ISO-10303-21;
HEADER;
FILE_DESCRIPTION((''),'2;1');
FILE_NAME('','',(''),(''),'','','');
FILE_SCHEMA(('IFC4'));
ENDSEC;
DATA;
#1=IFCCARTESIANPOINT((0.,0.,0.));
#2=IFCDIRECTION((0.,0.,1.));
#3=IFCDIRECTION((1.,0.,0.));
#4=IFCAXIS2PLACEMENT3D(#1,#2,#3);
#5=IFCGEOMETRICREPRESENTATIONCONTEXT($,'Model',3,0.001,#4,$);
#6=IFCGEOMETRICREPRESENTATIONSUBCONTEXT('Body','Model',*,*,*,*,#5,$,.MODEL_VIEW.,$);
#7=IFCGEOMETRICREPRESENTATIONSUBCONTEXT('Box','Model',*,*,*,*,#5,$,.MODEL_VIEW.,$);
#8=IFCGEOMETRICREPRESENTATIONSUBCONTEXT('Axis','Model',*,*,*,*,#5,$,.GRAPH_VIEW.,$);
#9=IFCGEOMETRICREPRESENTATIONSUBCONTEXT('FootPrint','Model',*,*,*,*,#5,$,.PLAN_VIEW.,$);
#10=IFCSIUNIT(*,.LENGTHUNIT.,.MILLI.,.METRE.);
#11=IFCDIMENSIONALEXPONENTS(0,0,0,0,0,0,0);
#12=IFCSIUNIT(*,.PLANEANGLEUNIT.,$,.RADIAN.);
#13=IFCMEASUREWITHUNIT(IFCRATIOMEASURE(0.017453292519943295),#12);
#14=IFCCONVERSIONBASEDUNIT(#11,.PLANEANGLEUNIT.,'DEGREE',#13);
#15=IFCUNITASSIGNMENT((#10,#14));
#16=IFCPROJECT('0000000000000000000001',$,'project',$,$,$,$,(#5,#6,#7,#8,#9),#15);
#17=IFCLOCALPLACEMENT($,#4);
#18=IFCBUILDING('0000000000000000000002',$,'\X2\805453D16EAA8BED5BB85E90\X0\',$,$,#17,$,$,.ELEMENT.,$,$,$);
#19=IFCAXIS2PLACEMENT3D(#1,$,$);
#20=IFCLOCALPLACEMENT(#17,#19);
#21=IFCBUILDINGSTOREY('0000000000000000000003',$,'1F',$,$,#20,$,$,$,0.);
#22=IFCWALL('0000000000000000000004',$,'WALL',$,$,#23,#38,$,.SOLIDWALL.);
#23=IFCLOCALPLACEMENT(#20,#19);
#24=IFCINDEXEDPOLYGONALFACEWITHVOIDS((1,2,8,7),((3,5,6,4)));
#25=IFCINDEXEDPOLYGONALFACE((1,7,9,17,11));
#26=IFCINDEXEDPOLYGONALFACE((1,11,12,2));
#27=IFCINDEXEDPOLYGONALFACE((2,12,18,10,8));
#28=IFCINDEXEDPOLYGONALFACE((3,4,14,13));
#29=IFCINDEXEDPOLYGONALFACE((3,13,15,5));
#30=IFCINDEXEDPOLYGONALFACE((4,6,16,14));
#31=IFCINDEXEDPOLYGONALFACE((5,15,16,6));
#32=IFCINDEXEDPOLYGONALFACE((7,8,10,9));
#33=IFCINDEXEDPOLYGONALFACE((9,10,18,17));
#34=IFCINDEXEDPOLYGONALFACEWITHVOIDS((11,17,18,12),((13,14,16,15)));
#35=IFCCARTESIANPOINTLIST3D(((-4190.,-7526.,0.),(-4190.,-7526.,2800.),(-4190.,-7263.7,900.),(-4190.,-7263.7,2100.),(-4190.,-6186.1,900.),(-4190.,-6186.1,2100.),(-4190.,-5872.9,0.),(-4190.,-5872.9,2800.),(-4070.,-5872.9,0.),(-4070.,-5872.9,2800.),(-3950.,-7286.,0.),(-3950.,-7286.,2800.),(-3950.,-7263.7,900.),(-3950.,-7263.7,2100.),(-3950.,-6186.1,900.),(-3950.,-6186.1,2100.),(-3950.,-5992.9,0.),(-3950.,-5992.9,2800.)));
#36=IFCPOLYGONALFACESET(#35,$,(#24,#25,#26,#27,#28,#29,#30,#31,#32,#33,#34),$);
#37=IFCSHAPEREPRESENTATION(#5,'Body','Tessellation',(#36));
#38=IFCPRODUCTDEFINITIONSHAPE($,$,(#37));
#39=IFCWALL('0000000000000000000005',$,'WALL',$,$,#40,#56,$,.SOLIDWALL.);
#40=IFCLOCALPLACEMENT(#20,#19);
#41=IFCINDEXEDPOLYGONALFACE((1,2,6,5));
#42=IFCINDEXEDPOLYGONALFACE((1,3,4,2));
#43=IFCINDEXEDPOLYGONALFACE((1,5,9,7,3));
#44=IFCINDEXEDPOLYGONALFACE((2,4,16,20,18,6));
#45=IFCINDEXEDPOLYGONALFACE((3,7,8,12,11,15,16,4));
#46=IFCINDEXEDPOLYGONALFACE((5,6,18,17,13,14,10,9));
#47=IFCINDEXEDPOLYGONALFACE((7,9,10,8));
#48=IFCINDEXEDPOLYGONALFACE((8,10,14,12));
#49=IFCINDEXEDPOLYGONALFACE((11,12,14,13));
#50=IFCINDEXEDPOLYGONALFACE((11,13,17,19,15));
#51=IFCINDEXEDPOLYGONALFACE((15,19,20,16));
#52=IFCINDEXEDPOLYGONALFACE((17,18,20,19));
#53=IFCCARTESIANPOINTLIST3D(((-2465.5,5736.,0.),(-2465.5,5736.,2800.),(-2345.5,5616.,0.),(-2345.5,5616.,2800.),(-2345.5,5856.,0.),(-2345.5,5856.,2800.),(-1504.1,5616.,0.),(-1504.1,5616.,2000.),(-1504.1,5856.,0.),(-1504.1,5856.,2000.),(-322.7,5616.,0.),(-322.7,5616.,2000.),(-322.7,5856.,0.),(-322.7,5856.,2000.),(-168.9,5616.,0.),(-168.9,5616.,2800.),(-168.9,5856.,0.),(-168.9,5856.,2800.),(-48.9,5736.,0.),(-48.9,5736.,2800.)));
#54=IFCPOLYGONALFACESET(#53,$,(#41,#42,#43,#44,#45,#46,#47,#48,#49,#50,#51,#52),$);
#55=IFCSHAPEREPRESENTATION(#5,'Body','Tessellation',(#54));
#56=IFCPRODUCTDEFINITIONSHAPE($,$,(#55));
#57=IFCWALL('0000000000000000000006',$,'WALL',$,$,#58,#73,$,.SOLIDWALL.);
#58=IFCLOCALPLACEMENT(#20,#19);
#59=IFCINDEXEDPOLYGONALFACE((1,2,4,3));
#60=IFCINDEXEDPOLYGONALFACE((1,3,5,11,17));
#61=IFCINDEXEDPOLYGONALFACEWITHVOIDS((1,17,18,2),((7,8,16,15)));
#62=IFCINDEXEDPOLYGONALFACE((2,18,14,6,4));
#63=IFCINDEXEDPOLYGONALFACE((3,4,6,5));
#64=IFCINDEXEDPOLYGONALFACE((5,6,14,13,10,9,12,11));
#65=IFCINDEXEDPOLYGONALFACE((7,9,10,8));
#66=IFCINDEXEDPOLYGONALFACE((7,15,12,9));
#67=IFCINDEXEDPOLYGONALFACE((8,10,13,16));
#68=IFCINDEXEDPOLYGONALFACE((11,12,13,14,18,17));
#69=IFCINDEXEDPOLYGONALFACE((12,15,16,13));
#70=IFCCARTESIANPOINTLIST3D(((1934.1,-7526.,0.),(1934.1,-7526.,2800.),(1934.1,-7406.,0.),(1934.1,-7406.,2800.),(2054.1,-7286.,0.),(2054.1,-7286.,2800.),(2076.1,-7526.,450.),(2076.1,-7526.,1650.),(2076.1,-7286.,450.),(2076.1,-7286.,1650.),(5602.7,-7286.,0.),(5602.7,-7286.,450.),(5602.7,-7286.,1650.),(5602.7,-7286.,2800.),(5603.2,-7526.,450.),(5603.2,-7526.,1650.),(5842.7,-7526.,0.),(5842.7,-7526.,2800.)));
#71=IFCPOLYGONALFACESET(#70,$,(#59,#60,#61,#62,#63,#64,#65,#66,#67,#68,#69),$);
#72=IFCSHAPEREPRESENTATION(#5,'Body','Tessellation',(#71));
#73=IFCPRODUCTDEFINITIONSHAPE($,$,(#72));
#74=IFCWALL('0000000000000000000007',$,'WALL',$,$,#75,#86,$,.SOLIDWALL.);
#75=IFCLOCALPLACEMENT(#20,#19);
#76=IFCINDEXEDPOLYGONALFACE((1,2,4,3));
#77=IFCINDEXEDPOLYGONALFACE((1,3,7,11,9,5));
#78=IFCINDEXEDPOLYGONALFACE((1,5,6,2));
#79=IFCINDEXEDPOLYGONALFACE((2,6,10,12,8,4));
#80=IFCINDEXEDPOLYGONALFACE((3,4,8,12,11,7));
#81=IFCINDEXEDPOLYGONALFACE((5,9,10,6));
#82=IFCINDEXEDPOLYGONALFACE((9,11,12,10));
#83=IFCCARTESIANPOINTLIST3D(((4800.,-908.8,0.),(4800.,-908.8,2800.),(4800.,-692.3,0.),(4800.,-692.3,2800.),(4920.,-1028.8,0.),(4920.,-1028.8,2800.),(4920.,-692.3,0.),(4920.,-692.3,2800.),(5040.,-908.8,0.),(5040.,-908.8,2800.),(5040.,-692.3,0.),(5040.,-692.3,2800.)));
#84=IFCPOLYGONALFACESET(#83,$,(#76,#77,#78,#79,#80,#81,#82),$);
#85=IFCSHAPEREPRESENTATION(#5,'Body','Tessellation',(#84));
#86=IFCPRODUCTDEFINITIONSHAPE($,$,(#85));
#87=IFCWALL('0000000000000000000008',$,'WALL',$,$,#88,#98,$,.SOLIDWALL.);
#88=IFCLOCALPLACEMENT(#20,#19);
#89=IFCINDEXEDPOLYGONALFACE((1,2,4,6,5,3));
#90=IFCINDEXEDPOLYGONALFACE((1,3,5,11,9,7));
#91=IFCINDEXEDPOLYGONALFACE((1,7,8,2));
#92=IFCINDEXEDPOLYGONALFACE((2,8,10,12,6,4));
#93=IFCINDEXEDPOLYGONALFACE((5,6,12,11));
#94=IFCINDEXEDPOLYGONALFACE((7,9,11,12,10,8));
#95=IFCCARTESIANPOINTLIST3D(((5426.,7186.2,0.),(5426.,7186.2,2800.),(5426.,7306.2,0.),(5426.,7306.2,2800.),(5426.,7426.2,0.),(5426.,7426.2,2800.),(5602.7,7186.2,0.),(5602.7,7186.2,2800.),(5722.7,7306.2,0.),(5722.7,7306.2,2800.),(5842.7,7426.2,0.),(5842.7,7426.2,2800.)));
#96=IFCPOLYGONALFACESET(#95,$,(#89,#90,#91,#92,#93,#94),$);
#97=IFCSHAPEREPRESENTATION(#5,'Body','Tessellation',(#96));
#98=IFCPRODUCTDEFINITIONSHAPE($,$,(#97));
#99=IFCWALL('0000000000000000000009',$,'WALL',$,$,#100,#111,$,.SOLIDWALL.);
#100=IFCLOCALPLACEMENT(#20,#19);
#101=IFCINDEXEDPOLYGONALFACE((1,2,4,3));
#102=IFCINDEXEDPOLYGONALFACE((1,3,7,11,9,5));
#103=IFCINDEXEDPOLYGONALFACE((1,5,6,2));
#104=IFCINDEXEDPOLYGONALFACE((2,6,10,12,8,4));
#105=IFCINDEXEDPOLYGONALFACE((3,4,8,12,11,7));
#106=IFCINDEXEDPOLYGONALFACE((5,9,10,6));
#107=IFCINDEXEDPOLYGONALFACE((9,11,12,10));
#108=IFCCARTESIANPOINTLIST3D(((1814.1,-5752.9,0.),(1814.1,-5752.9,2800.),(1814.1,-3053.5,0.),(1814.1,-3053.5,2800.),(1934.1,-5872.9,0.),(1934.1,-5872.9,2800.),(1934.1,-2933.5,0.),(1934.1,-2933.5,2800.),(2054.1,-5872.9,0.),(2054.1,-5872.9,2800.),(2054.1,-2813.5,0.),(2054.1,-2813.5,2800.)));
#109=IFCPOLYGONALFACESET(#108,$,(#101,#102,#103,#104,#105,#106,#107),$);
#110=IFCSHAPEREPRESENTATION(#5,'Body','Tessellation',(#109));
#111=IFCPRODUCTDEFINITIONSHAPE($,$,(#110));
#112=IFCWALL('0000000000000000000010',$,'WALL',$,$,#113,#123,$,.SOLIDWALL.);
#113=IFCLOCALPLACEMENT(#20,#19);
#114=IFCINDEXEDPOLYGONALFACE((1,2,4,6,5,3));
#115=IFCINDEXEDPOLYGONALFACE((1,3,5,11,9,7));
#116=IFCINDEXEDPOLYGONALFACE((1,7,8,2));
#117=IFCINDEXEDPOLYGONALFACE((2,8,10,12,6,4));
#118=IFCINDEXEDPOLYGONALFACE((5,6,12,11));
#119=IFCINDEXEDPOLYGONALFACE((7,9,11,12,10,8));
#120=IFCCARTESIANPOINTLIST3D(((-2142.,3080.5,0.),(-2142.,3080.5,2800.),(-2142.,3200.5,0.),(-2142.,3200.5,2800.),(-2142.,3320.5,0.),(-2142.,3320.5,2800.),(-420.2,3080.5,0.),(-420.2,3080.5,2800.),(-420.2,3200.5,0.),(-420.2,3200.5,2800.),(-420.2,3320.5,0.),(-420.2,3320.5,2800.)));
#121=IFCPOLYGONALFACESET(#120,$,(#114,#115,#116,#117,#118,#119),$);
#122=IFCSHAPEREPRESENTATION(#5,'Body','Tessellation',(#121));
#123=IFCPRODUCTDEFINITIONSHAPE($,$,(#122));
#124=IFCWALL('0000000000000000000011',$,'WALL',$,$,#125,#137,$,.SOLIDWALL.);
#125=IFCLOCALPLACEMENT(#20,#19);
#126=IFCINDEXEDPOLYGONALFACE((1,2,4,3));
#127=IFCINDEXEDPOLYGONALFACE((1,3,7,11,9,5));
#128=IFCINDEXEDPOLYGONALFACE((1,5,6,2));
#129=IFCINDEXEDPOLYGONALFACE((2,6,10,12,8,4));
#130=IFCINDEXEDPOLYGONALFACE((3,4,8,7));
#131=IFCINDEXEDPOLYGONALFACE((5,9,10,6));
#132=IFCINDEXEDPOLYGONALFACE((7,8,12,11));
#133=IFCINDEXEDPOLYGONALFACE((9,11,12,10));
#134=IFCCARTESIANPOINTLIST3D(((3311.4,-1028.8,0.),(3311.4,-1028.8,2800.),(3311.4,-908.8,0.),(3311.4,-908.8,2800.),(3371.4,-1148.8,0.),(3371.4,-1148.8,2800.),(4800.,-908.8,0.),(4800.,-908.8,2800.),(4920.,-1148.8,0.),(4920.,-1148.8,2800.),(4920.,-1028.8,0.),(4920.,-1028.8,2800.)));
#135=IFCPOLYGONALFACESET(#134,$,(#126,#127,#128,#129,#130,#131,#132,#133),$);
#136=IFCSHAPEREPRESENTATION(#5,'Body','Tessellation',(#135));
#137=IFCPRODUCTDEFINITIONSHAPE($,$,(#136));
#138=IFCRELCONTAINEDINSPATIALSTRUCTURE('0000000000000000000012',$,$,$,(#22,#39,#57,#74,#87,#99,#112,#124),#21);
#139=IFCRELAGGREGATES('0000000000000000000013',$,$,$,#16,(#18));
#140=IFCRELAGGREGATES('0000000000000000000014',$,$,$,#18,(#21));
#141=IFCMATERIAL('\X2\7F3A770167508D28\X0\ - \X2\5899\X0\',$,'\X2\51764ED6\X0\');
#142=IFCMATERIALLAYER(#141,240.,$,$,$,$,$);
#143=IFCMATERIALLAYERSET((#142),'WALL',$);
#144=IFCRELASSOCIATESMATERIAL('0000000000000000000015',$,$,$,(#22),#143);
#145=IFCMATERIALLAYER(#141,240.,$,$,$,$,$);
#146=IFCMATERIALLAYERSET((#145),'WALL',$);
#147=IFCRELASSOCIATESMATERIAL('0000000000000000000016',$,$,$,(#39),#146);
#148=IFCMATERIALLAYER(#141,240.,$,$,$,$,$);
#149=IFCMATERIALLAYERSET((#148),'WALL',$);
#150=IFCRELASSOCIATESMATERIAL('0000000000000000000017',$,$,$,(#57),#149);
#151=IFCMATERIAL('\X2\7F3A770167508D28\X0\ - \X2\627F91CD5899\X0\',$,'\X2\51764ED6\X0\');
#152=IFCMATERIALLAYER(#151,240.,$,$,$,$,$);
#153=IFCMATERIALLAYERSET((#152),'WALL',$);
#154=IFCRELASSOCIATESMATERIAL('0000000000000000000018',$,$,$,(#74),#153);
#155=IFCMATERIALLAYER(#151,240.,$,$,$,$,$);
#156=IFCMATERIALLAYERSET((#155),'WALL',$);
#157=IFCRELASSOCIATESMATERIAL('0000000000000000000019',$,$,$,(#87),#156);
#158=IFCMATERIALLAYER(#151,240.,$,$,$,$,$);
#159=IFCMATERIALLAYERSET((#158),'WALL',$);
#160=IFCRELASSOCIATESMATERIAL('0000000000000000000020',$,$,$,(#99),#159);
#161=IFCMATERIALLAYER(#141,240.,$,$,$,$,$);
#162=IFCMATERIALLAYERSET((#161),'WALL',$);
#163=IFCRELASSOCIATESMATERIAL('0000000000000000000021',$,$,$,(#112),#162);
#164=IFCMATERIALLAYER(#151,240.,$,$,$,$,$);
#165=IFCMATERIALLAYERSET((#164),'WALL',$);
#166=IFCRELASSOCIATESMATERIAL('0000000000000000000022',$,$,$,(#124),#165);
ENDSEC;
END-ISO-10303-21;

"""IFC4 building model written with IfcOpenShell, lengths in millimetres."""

from ifc_helpers import new_model, entity, si_unit, converted_unit, frame, origin, origin_with_axes, place, context, subcontext, project, spatial, polyline, segment, composite_curve, outline, extrude, material, layer, layer_set, layer_usage, element, save


model = new_model("IFC4")

# Units and contexts
model_context = context("Model", 3, precision=0.001, world=origin_with_axes())
body_context = subcontext(model_context, "Body", "Model", "MODEL_VIEW")
box_context = subcontext(model_context, "Box", "Model", "MODEL_VIEW")
axis_context = subcontext(model_context, "Axis", "Model", "GRAPH_VIEW")
footprint_context = subcontext(model_context, "FootPrint", "Model", "PLAN_VIEW")
ifc_project = project(units=[si_unit("LENGTHUNIT", "METRE", prefix="MILLI"), converted_unit("PLANEANGLEUNIT", "DEGREE", entity("IfcRatioMeasure", 0.017453292519943295), si_unit("PLANEANGLEUNIT", "RADIAN"), dimensions=[0, 0, 0, 0, 0, 0, 0])], contexts=[model_context, body_context, box_context, axis_context, footprint_context])

# Building, storey
building_placement = place(None, origin_with_axes())
building = spatial("IfcBuilding", under=ifc_project, at=building_placement, Name="联发溪语宸庐", CompositionType="ELEMENT")
storey_placement = place(building_placement, origin())
storey = spatial("IfcBuildingStorey", under=building, at=storey_placement, Name="1F", Elevation=0.0)

# Walls, openings
ifc_material_1 = material(Name="缺省材质 - 墙", Category="其他")
ifc_layer_1 = layer(ifc_material_1, 240.0)
ifc_layer_set_1 = layer_set([ifc_layer_1], Name="WALL")
ifc_layer_usage_1 = layer_usage(ifc_layer_set_1, "AXIS2", "NEGATIVE", 120.0)
wall_1_placement = place(None, origin_with_axes())
wall_1 = element("IfcWall", 1, at=wall_1_placement, inside=storey, material=ifc_layer_usage_1, Name="WALL", PredefinedType="SOLIDWALL", context=model_context, shape_type="SweptSolid", body=[
    extrude(outline(composite_curve([segment(polyline([(-4070.0, -5872.9), (-4190.0, -5872.9)]), True, "CONTINUOUS"), segment(polyline([(-4190.0, -5872.9), (-4190.0, -7526.0)]), True, "CONTINUOUS"), segment(polyline([(-4190.0, -7526.0), (-4070.0, -7406.0)]), True, "CONTINUOUS"), segment(polyline([(-4070.0, -7406.0), (-3950.0, -7286.0)]), True, "CONTINUOUS"), segment(polyline([(-3950.0, -7286.0), (-3950.0, -5992.9)]), True, "CONTINUOUS"), segment(polyline([(-3950.0, -5992.9), (-4070.0, -5872.9)]), True, "CONTINUOUS")], self_intersect=False)), origin(), (0.0, 0.0, 1.0), 2800.0),
])
opening_1_placement = place(None, origin_with_axes())
element("IfcOpeningElement", 2, at=opening_1_placement, cuts=wall_1, ObjectType="OPENING", PredefinedType="OPENING", context=model_context, shape_type="SweptSolid", body=[
    extrude(outline(composite_curve([segment(polyline([(-3950.0, -7263.7), (-3950.0, -6186.1)]), True, "CONTINUOUS"), segment(polyline([(-3950.0, -6186.1), (-4190.0, -6186.1)]), True, "CONTINUOUS"), segment(polyline([(-4190.0, -6186.1), (-4190.0, -7263.7)]), True, "CONTINUOUS"), segment(polyline([(-4190.0, -7263.7), (-3950.0, -7263.7)]), True, "CONTINUOUS")], self_intersect=False)), frame((0.0, 0.0, 900.0), z_axis=(0.0, 0.0, 1.0), x_axis=(1.0, 0.0, 0.0)), (0.0, 0.0, 1.0), 1200.0),
])
ifc_layer_2 = layer(ifc_material_1, 240.0)
ifc_layer_set_2 = layer_set([ifc_layer_2], Name="WALL")
ifc_layer_usage_2 = layer_usage(ifc_layer_set_2, "AXIS2", "NEGATIVE", 120.0)
wall_2_placement = place(None, origin_with_axes())
wall_2 = element("IfcWall", 3, at=wall_2_placement, inside=storey, material=ifc_layer_usage_2, Name="WALL", PredefinedType="SOLIDWALL", context=model_context, shape_type="SweptSolid", body=[
    extrude(outline(composite_curve([segment(polyline([(-2465.5, 5736.0), (-2345.5, 5616.0)]), True, "CONTINUOUS"), segment(polyline([(-2345.5, 5616.0), (-168.9, 5616.0)]), True, "CONTINUOUS"), segment(polyline([(-168.9, 5616.0), (-48.9, 5736.0)]), True, "CONTINUOUS"), segment(polyline([(-48.9, 5736.0), (-168.9, 5856.0)]), True, "CONTINUOUS"), segment(polyline([(-168.9, 5856.0), (-2345.5, 5856.0)]), True, "CONTINUOUS"), segment(polyline([(-2345.5, 5856.0), (-2465.5, 5736.0)]), True, "CONTINUOUS")], self_intersect=False)), origin(), (0.0, 0.0, 1.0), 2800.0),
])
opening_2_placement = place(None, origin_with_axes())
element("IfcOpeningElement", 4, at=opening_2_placement, cuts=wall_2, ObjectType="OPENING", PredefinedType="OPENING", context=model_context, shape_type="SweptSolid", body=[
    extrude(outline(composite_curve([segment(polyline([(-322.7, 5856.0), (-1504.1, 5856.0)]), True, "CONTINUOUS"), segment(polyline([(-1504.1, 5856.0), (-1504.1, 5616.0)]), True, "CONTINUOUS"), segment(polyline([(-1504.1, 5616.0), (-322.7, 5616.0)]), True, "CONTINUOUS"), segment(polyline([(-322.7, 5616.0), (-322.7, 5856.0)]), True, "CONTINUOUS")], self_intersect=False)), origin_with_axes(), (0.0, 0.0, 1.0), 2000.0),
])
ifc_layer_3 = layer(ifc_material_1, 240.0)
ifc_layer_set_3 = layer_set([ifc_layer_3], Name="WALL")
ifc_layer_usage_3 = layer_usage(ifc_layer_set_3, "AXIS2", "NEGATIVE", 120.0)
wall_3_placement = place(None, origin_with_axes())
wall_3 = element("IfcWall", 5, at=wall_3_placement, inside=storey, material=ifc_layer_usage_3, Name="WALL", PredefinedType="SOLIDWALL", context=model_context, shape_type="SweptSolid", body=[
    extrude(outline(composite_curve([segment(polyline([(1934.1, -7406.0), (1934.1, -7526.0)]), True, "CONTINUOUS"), segment(polyline([(1934.1, -7526.0), (5842.7, -7526.0)]), True, "CONTINUOUS"), segment(polyline([(5842.7, -7526.0), (5722.7, -7406.0)]), True, "CONTINUOUS"), segment(polyline([(5722.7, -7406.0), (5602.7, -7286.0)]), True, "CONTINUOUS"), segment(polyline([(5602.7, -7286.0), (2054.1, -7286.0)]), True, "CONTINUOUS"), segment(polyline([(2054.1, -7286.0), (1934.1, -7406.0)]), True, "CONTINUOUS")], self_intersect=False)), origin(), (0.0, 0.0, 1.0), 2800.0),
])
opening_3_placement = place(None, origin_with_axes())
element("IfcOpeningElement", 6, at=opening_3_placement, cuts=wall_3, ObjectType="OPENING", PredefinedType="OPENING", context=model_context, shape_type="SweptSolid", body=[
    extrude(outline(composite_curve([segment(polyline([(5602.7, -7286.0), (2076.1, -7286.0)]), True, "CONTINUOUS"), segment(polyline([(2076.1, -7286.0), (2076.1, -7526.0)]), True, "CONTINUOUS"), segment(polyline([(2076.1, -7526.0), (5603.2, -7526.0)]), True, "CONTINUOUS"), segment(polyline([(5603.2, -7526.0), (5602.7, -7286.0)]), True, "CONTINUOUS")], self_intersect=False)), frame((0.0, 0.0, 450.0), z_axis=(0.0, 0.0, 1.0), x_axis=(1.0, 0.0, 0.0)), (0.0, 0.0, 1.0), 1200.0),
])

# Walls
ifc_material_2 = material(Name="缺省材质 - 承重墙", Category="其他")
ifc_layer_4 = layer(ifc_material_2, 240.0)
ifc_layer_set_4 = layer_set([ifc_layer_4], Name="WALL")
ifc_layer_usage_4 = layer_usage(ifc_layer_set_4, "AXIS2", "NEGATIVE", 120.0)
wall_4_placement = place(None, origin_with_axes())
element("IfcWall", 7, at=wall_4_placement, inside=storey, material=ifc_layer_usage_4, Name="WALL", PredefinedType="SOLIDWALL", context=model_context, shape_type="SweptSolid", body=[
    extrude(outline(composite_curve([segment(polyline([(4920.0, -1028.8), (5040.0, -908.8)]), True, "CONTINUOUS"), segment(polyline([(5040.0, -908.8), (5040.0, -692.3)]), True, "CONTINUOUS"), segment(polyline([(5040.0, -692.3), (4920.0, -692.3)]), True, "CONTINUOUS"), segment(polyline([(4920.0, -692.3), (4800.0, -692.3)]), True, "CONTINUOUS"), segment(polyline([(4800.0, -692.3), (4800.0, -908.8)]), True, "CONTINUOUS"), segment(polyline([(4800.0, -908.8), (4920.0, -1028.8)]), True, "CONTINUOUS")], self_intersect=False)), origin(), (0.0, 0.0, 1.0), 2800.0),
])
ifc_layer_5 = layer(ifc_material_2, 240.0)
ifc_layer_set_5 = layer_set([ifc_layer_5], Name="WALL")
ifc_layer_usage_5 = layer_usage(ifc_layer_set_5, "AXIS2", "NEGATIVE", 120.0)
wall_5_placement = place(None, origin_with_axes())
element("IfcWall", 8, at=wall_5_placement, inside=storey, material=ifc_layer_usage_5, Name="WALL", PredefinedType="SOLIDWALL", context=model_context, shape_type="SweptSolid", body=[
    extrude(outline(composite_curve([segment(polyline([(5722.7, 7306.2), (5842.7, 7426.2)]), True, "CONTINUOUS"), segment(polyline([(5842.7, 7426.2), (5426.0, 7426.2)]), True, "CONTINUOUS"), segment(polyline([(5426.0, 7426.2), (5426.0, 7306.2)]), True, "CONTINUOUS"), segment(polyline([(5426.0, 7306.2), (5426.0, 7186.2)]), True, "CONTINUOUS"), segment(polyline([(5426.0, 7186.2), (5602.7, 7186.2)]), True, "CONTINUOUS"), segment(polyline([(5602.7, 7186.2), (5722.7, 7306.2)]), True, "CONTINUOUS")], self_intersect=False)), origin(), (0.0, 0.0, 1.0), 2800.0),
])
ifc_layer_6 = layer(ifc_material_2, 240.0)
ifc_layer_set_6 = layer_set([ifc_layer_6], Name="WALL")
ifc_layer_usage_6 = layer_usage(ifc_layer_set_6, "AXIS2", "NEGATIVE", 120.0)
wall_6_placement = place(None, origin_with_axes())
element("IfcWall", 9, at=wall_6_placement, inside=storey, material=ifc_layer_usage_6, Name="WALL", PredefinedType="SOLIDWALL", context=model_context, shape_type="SweptSolid", body=[
    extrude(outline(composite_curve([segment(polyline([(1934.1, -5872.9), (2054.1, -5872.9)]), True, "CONTINUOUS"), segment(polyline([(2054.1, -5872.9), (2054.1, -2813.5)]), True, "CONTINUOUS"), segment(polyline([(2054.1, -2813.5), (1934.1, -2933.5)]), True, "CONTINUOUS"), segment(polyline([(1934.1, -2933.5), (1814.1, -3053.5)]), True, "CONTINUOUS"), segment(polyline([(1814.1, -3053.5), (1814.1, -5752.9)]), True, "CONTINUOUS"), segment(polyline([(1814.1, -5752.9), (1934.1, -5872.9)]), True, "CONTINUOUS")], self_intersect=False)), origin(), (0.0, 0.0, 1.0), 2800.0),
])
ifc_layer_7 = layer(ifc_material_1, 240.0)
ifc_layer_set_7 = layer_set([ifc_layer_7], Name="WALL")
ifc_layer_usage_7 = layer_usage(ifc_layer_set_7, "AXIS2", "NEGATIVE", 120.0)
wall_7_placement = place(None, origin_with_axes())
element("IfcWall", 10, at=wall_7_placement, inside=storey, material=ifc_layer_usage_7, Name="WALL", PredefinedType="SOLIDWALL", context=model_context, shape_type="SweptSolid", body=[
    extrude(outline(composite_curve([segment(polyline([(-420.2, 3200.5), (-420.2, 3320.5)]), True, "CONTINUOUS"), segment(polyline([(-420.2, 3320.5), (-2142.0, 3320.5)]), True, "CONTINUOUS"), segment(polyline([(-2142.0, 3320.5), (-2142.0, 3200.5)]), True, "CONTINUOUS"), segment(polyline([(-2142.0, 3200.5), (-2142.0, 3080.5)]), True, "CONTINUOUS"), segment(polyline([(-2142.0, 3080.5), (-420.2, 3080.5)]), True, "CONTINUOUS"), segment(polyline([(-420.2, 3080.5), (-420.2, 3200.5)]), True, "CONTINUOUS")], self_intersect=False)), origin(), (0.0, 0.0, 1.0), 2800.0),
])
ifc_layer_8 = layer(ifc_material_2, 240.0)
ifc_layer_set_8 = layer_set([ifc_layer_8], Name="WALL")
ifc_layer_usage_8 = layer_usage(ifc_layer_set_8, "AXIS2", "NEGATIVE", 120.0)
wall_8_placement = place(None, origin_with_axes())
element("IfcWall", 11, at=wall_8_placement, inside=storey, material=ifc_layer_usage_8, Name="WALL", PredefinedType="SOLIDWALL", context=model_context, shape_type="SweptSolid", body=[
    extrude(outline(composite_curve([segment(polyline([(4920.0, -1028.8), (4800.0, -908.8)]), True, "CONTINUOUS"), segment(polyline([(4800.0, -908.8), (3311.4, -908.8)]), True, "CONTINUOUS"), segment(polyline([(3311.4, -908.8), (3311.4, -1028.8)]), True, "CONTINUOUS"), segment(polyline([(3311.4, -1028.8), (3371.4, -1148.8)]), True, "CONTINUOUS"), segment(polyline([(3371.4, -1148.8), (4920.0, -1148.8)]), True, "CONTINUOUS"), segment(polyline([(4920.0, -1148.8), (4920.0, -1028.8)]), True, "CONTINUOUS")], self_intersect=False)), origin(), (0.0, 0.0, 1.0), 2800.0),
])

save(model, "model.ifc")
